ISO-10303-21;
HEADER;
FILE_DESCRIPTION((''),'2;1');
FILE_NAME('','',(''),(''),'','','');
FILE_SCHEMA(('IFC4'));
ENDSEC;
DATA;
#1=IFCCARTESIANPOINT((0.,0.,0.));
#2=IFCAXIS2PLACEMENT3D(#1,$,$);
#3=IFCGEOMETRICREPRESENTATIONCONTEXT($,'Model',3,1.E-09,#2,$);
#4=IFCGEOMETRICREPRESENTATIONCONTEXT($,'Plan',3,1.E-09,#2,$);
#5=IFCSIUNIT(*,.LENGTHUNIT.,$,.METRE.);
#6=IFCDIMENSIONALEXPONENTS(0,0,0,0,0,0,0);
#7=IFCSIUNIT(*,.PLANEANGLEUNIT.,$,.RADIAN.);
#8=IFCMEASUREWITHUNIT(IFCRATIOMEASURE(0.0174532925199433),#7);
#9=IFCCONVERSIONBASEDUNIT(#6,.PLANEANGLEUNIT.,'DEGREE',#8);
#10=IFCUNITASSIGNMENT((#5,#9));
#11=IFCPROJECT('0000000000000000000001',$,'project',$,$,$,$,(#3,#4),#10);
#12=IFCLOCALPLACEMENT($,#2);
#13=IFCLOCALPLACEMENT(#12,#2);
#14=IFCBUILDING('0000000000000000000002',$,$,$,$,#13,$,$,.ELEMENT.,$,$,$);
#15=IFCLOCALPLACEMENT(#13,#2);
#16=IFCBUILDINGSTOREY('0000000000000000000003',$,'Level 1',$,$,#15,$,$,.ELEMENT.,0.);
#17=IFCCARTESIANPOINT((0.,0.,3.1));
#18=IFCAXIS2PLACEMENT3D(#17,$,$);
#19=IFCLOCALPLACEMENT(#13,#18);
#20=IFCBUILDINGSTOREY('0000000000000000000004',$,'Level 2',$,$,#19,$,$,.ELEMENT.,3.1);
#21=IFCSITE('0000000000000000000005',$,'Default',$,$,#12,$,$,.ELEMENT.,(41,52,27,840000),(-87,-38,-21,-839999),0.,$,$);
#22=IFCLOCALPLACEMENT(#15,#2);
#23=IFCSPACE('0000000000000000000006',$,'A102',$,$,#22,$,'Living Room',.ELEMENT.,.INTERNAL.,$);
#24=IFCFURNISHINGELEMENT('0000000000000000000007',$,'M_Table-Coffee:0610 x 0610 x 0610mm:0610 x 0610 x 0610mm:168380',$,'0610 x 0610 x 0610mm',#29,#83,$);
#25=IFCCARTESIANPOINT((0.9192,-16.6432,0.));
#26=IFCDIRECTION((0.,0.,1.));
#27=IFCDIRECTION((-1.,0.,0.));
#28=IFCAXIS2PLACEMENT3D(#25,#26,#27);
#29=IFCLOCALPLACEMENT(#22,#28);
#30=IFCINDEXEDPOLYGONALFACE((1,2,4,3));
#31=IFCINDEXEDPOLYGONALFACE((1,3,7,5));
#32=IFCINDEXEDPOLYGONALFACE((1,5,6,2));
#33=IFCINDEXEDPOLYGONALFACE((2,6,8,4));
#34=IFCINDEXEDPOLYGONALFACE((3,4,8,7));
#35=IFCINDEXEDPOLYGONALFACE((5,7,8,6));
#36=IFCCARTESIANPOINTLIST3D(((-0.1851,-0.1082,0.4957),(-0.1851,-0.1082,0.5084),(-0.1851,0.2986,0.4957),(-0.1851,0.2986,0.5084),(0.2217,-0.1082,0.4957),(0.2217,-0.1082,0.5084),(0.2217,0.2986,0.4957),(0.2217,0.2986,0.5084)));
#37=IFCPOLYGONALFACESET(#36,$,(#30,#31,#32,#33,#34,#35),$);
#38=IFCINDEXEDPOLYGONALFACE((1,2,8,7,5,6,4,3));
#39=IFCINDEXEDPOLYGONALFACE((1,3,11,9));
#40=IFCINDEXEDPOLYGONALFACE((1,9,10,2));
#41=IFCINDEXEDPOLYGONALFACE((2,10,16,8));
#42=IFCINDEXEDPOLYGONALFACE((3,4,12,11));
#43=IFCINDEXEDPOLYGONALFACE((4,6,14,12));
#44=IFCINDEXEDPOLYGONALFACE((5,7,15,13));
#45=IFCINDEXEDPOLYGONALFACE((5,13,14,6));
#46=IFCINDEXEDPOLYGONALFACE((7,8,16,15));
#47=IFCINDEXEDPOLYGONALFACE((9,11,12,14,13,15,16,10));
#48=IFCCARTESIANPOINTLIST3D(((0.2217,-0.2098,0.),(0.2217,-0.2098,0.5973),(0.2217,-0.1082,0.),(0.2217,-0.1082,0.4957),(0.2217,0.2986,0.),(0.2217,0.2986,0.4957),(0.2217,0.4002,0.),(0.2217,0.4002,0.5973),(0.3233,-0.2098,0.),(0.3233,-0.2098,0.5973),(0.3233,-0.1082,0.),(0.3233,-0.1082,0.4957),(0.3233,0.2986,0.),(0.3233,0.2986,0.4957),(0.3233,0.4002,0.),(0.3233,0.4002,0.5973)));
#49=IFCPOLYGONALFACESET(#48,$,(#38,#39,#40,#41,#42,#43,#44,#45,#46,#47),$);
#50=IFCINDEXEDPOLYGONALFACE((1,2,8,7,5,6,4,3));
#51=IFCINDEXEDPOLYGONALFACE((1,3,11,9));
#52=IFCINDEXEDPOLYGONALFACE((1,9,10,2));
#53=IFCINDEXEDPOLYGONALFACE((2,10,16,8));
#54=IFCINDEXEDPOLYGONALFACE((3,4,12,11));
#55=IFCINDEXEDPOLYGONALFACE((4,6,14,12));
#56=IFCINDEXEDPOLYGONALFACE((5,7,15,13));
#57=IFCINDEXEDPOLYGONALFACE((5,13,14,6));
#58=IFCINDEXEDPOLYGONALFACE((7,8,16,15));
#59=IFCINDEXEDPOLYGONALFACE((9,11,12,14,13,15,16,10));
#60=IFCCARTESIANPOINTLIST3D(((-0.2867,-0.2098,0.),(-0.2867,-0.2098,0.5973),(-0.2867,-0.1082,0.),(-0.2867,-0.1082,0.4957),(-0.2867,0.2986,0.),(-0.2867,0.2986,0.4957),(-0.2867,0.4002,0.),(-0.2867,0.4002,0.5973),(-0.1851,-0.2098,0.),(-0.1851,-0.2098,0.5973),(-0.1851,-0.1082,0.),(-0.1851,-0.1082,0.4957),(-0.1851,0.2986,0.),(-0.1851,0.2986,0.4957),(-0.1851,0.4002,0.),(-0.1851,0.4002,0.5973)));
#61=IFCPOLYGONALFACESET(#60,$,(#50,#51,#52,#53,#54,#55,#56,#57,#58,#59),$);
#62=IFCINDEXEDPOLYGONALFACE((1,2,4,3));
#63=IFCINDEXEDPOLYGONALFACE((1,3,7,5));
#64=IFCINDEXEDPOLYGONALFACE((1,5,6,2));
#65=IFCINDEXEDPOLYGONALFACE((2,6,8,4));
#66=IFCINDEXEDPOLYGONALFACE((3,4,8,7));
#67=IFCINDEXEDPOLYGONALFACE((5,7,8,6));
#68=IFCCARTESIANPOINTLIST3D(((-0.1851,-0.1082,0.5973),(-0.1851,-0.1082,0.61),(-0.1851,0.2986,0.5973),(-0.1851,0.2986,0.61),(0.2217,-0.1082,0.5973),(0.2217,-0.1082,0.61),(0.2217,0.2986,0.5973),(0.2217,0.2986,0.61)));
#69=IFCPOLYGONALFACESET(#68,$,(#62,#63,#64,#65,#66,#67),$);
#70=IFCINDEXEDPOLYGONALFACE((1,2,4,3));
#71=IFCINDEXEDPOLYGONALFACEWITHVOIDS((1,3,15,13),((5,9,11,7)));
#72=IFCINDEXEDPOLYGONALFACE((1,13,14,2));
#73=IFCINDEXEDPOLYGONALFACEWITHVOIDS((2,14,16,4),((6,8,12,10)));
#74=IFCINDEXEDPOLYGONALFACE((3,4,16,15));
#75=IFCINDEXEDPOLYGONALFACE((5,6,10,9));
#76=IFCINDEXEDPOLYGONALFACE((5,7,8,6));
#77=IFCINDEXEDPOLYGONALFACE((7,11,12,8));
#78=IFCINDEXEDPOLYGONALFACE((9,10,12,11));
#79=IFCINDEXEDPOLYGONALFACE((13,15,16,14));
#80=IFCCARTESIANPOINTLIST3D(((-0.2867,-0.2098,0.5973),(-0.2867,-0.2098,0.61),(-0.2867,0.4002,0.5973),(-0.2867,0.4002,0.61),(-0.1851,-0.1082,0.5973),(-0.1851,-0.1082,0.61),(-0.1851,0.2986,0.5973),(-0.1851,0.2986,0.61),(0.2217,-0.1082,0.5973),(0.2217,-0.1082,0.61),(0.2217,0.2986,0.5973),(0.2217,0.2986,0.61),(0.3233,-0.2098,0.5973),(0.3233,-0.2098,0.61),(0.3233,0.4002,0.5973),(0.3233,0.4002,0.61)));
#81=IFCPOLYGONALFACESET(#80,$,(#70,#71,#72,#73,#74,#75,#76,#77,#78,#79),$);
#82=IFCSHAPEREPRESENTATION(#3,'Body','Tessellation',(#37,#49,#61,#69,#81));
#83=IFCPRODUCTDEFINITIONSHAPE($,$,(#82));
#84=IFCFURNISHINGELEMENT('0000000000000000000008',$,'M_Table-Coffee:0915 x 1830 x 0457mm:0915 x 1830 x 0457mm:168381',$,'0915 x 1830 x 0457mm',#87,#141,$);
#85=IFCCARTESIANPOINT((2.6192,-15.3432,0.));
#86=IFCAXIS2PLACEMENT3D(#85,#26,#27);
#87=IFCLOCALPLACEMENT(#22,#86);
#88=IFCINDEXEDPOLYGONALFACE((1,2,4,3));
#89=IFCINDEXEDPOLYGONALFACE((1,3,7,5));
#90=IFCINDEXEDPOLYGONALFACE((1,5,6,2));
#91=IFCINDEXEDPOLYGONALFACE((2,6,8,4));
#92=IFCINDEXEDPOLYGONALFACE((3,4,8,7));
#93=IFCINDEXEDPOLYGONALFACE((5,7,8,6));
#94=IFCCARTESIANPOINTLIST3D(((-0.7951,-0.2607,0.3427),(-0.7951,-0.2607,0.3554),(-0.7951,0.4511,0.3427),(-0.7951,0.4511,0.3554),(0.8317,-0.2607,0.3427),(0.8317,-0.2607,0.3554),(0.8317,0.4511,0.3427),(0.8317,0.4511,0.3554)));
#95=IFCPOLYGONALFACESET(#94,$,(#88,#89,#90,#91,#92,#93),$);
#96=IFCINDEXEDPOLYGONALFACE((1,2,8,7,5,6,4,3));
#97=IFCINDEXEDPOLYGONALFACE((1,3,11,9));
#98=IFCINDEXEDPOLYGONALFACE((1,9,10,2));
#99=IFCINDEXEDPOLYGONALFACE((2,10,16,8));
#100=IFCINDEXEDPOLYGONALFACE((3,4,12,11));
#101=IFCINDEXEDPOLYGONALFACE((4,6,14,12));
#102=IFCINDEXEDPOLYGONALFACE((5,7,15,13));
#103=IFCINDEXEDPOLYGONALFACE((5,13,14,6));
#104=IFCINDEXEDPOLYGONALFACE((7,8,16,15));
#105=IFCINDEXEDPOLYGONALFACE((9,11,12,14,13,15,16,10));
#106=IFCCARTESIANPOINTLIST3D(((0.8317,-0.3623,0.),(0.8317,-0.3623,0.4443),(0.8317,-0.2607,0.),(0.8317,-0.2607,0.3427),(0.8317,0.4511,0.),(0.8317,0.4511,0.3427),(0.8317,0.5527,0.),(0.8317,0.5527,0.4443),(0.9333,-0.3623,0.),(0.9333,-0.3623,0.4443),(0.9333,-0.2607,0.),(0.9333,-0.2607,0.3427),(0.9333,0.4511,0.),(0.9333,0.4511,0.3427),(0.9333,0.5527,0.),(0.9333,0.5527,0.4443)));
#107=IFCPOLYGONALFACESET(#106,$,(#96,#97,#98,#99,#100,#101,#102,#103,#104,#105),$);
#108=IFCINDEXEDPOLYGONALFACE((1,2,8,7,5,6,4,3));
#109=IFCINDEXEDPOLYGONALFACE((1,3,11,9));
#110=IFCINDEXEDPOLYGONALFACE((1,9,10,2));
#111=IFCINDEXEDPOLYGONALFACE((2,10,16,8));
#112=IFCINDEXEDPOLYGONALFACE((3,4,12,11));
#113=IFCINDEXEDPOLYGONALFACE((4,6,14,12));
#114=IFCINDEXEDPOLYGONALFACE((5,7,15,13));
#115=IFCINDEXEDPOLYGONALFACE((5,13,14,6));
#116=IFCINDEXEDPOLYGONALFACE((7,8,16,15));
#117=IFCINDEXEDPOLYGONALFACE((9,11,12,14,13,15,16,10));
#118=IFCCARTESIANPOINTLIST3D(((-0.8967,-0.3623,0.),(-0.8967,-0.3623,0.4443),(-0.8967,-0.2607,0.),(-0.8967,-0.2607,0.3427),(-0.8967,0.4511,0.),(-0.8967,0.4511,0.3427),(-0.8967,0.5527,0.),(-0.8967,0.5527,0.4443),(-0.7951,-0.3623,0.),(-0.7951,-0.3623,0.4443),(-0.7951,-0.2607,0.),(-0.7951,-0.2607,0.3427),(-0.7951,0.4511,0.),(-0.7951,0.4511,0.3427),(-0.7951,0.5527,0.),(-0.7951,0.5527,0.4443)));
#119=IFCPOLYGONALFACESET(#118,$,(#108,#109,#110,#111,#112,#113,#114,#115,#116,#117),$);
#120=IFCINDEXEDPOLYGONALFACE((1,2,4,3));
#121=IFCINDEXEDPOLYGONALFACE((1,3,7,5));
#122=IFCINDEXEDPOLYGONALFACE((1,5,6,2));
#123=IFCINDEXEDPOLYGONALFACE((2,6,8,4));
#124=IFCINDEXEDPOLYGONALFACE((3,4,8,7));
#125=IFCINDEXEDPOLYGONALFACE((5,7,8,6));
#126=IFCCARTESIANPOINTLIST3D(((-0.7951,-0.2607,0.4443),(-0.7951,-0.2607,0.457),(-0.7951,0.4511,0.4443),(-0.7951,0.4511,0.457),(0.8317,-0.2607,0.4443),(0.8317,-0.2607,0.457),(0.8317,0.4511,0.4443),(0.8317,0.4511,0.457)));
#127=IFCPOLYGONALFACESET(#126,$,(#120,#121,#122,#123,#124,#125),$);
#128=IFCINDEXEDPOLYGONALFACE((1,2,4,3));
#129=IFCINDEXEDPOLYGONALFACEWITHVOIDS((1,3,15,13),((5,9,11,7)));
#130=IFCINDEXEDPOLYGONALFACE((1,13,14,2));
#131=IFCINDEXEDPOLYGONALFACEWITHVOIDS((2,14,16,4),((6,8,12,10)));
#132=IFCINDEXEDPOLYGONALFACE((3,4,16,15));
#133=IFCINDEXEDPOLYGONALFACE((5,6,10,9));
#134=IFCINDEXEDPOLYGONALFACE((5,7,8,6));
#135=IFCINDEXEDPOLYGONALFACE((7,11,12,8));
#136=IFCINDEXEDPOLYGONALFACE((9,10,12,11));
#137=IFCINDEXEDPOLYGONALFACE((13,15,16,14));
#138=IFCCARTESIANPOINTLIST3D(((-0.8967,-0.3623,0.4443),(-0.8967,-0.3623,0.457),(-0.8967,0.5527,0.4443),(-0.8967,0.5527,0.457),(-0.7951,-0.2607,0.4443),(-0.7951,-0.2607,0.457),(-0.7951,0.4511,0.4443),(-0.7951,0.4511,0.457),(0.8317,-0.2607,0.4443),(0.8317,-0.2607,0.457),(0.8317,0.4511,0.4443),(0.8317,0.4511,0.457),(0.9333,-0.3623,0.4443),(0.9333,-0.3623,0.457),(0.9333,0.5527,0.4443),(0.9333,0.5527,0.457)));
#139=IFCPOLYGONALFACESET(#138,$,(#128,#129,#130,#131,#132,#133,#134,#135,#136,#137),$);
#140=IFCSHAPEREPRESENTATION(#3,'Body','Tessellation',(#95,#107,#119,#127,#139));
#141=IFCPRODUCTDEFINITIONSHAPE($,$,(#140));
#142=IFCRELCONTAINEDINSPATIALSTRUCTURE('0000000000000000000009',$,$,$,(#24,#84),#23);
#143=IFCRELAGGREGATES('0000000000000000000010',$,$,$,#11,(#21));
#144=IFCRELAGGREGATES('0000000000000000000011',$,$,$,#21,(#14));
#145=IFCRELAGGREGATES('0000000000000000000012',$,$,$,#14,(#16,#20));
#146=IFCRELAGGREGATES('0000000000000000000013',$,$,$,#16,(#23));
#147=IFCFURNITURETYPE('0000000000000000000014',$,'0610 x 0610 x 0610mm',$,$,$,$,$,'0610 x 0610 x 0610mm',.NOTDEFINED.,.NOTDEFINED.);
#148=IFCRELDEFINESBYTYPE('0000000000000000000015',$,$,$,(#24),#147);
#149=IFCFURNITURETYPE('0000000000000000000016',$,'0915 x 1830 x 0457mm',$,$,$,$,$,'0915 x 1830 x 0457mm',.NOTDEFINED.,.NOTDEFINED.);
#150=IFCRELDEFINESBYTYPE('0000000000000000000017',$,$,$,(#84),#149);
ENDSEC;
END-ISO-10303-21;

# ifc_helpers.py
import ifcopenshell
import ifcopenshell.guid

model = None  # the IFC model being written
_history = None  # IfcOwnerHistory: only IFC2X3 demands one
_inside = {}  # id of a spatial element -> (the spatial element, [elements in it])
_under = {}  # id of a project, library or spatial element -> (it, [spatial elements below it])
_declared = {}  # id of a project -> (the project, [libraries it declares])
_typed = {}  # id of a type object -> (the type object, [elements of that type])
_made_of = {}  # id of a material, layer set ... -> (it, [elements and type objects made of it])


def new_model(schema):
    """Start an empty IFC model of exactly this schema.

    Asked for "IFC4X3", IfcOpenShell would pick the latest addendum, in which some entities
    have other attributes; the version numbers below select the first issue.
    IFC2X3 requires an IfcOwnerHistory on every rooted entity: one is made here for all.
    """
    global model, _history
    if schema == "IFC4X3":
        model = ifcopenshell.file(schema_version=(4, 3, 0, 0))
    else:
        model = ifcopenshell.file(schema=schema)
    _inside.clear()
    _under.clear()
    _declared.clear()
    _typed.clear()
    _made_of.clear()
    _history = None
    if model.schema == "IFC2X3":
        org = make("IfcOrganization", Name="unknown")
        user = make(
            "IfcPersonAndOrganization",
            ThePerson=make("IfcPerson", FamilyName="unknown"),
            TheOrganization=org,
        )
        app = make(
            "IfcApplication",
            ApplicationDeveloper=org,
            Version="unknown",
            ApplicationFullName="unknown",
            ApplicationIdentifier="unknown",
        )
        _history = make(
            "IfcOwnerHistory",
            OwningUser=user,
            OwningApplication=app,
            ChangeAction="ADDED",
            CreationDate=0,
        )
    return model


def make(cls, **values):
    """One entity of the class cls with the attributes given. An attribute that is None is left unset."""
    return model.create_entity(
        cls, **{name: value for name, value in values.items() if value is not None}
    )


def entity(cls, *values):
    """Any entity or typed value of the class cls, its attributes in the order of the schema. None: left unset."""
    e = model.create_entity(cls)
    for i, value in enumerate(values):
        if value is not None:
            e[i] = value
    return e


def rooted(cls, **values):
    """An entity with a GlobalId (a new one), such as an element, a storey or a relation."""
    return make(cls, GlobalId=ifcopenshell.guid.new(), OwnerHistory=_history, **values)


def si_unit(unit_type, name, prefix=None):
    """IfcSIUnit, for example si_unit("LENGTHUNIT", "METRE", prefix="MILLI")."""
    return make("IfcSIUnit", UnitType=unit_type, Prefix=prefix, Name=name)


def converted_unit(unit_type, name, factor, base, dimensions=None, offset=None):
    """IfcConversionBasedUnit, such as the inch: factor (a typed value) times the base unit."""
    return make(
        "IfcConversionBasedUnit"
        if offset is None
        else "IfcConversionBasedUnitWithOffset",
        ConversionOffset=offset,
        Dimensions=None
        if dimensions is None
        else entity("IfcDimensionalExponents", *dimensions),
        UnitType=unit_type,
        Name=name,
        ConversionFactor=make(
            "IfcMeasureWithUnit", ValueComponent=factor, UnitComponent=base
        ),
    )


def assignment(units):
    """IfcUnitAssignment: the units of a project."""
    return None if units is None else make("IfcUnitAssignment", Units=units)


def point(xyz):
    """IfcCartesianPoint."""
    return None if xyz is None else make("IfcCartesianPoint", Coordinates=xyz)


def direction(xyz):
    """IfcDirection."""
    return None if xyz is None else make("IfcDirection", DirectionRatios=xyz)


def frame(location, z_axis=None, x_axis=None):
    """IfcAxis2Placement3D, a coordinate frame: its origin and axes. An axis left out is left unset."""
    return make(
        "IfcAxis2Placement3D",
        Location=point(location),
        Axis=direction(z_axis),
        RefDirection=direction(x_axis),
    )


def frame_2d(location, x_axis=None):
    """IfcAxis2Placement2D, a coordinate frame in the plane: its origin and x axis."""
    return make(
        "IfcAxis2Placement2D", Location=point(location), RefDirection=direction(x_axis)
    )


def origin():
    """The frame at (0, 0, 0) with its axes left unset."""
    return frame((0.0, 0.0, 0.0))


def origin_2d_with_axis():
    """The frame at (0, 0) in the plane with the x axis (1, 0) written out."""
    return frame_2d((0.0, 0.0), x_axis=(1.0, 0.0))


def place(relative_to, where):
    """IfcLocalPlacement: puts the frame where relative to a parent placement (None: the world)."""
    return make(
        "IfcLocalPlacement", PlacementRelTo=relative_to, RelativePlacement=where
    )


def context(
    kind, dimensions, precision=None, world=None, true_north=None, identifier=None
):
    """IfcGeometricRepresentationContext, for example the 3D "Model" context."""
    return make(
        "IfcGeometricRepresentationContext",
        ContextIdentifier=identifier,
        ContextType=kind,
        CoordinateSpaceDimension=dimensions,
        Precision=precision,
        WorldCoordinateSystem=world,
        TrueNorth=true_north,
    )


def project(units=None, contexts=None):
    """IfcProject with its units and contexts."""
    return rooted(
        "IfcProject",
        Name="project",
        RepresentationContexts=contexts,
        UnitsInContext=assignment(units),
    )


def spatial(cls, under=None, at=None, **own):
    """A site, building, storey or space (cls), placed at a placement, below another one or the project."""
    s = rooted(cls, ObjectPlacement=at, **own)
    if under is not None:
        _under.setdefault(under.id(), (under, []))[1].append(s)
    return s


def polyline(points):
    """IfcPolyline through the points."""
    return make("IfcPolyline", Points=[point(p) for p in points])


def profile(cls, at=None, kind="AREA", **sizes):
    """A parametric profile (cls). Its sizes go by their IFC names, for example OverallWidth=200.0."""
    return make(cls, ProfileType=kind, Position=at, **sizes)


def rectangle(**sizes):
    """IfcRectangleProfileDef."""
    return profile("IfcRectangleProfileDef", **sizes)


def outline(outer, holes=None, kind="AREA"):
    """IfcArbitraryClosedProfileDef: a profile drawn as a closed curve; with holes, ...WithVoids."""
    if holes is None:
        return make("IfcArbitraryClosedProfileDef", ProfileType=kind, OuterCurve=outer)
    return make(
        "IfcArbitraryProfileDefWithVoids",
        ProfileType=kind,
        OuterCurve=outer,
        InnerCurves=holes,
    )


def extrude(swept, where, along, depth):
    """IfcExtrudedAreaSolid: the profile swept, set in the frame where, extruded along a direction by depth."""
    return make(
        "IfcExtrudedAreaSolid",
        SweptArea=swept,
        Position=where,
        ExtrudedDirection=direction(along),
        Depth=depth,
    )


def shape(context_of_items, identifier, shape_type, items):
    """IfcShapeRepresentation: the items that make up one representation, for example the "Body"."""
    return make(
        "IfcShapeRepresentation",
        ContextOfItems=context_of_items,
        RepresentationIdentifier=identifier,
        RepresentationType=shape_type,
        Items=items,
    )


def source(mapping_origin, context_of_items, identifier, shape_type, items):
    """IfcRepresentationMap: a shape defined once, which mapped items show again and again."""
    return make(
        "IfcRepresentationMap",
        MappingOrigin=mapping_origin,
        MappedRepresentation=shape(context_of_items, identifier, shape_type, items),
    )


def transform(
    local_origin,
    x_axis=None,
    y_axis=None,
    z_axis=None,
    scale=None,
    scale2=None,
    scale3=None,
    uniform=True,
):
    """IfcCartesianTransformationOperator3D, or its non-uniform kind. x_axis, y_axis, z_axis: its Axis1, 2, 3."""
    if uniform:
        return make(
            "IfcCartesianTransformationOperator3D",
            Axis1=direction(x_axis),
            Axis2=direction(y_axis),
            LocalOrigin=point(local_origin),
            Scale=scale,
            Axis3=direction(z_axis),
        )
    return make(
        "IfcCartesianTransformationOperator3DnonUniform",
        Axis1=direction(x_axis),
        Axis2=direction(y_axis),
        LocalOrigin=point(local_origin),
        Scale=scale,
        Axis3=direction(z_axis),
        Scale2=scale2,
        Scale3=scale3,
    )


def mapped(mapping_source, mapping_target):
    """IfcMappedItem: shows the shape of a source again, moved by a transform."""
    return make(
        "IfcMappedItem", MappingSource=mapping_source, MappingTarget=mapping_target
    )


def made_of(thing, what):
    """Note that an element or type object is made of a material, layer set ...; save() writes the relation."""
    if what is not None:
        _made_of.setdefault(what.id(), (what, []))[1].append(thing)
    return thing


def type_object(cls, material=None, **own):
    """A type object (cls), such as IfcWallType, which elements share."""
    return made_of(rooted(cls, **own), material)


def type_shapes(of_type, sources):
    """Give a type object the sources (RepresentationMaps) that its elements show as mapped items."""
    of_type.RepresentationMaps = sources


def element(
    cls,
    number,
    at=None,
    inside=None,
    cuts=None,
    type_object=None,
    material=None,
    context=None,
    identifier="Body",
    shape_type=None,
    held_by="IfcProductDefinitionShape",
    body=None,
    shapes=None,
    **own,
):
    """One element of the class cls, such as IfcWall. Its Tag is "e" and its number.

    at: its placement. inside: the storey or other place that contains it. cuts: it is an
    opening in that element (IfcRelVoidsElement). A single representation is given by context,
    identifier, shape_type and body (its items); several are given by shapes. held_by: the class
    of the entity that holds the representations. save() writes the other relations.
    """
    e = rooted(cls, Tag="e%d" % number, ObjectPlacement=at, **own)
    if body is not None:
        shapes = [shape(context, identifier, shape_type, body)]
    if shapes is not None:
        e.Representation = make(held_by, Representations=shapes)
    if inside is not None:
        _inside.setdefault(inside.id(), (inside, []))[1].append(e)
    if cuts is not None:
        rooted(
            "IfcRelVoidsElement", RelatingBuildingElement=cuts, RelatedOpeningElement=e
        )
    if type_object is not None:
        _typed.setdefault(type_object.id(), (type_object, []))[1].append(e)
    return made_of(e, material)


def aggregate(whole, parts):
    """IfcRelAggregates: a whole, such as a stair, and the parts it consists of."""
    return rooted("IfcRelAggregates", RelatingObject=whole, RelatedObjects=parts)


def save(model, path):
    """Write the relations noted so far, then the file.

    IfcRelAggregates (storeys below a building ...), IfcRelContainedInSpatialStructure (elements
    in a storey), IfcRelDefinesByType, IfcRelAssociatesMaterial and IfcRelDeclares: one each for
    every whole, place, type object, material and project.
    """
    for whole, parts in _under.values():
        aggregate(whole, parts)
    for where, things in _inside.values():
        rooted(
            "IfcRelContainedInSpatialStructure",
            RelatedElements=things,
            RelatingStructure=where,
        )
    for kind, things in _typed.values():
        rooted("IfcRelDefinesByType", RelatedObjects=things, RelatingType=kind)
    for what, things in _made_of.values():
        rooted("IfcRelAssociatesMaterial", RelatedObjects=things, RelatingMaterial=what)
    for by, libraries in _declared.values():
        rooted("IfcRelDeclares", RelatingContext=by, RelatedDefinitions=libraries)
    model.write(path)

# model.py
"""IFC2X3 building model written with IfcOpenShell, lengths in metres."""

from ifc_helpers import new_model, entity, si_unit, converted_unit, frame, origin, origin_2d_with_axis, place, context, project, spatial, polyline, rectangle, outline, extrude, source, transform, mapped, type_object, type_shapes, element, save


model = new_model("IFC2X3")

# Units and contexts
model_context = context("Model", 3, precision=1e-09, world=origin())
plan_context = context("Plan", 3, precision=1e-09, world=origin())
ifc_project = project(units=[si_unit("LENGTHUNIT", "METRE"), converted_unit("PLANEANGLEUNIT", "DEGREE", entity("IfcRatioMeasure", 0.0174532925199433), si_unit("PLANEANGLEUNIT", "RADIAN"), dimensions=[0, 0, 0, 0, 0, 0, 0])], contexts=[model_context, plan_context])

# Site, building, storey
site_placement = place(None, origin())
site = spatial("IfcSite", under=ifc_project, at=site_placement, Name="Default", CompositionType="ELEMENT", RefLatitude=(41, 52, 27, 840000), RefLongitude=(-87, -38, -21, -839999), RefElevation=0.0)
building_placement = place(site_placement, origin())
building = spatial("IfcBuilding", under=site, at=building_placement, CompositionType="ELEMENT")
storey_1_placement = place(building_placement, origin())
storey_1 = spatial("IfcBuildingStorey", under=building, at=storey_1_placement, Name="Level 1", CompositionType="ELEMENT", Elevation=0.0)

# Shared definitions
storey_2_placement = place(building_placement, frame((0.0, 0.0, 3.1)))
storey_2 = spatial("IfcBuildingStorey", under=building, at=storey_2_placement, Name="Level 2", CompositionType="ELEMENT", Elevation=3.1)

# Shared definitions
space_1_placement = place(storey_1_placement, origin())
space_1 = spatial("IfcSpace", under=storey_1, at=space_1_placement, Name="A102", LongName="Living Room", CompositionType="ELEMENT", InteriorOrExteriorSpace="INTERNAL")

# Furnishing elements
furniture_type_1 = type_object("IfcFurnitureType", Name="0610 x 0610 x 0610mm", ElementType="0610 x 0610 x 0610mm", AssemblyPlace="NOTDEFINED")
shared_shape_1 = source(origin(), model_context, "Body", "SweptSolid", [
    extrude(rectangle(XDim=0.4068, YDim=0.4068, at=origin_2d_with_axis()), frame((0.0183, 0.0952, 0.4957), z_axis=(0.0, 0.0, 1.0), x_axis=(-1.0, 0.0, 0.0)), (0.0, 0.0, 1.0), 0.0127),
    extrude(outline(polyline([(-0.2732, -0.305), (0.324, -0.305), (0.324, 0.305), (-0.2732, 0.305), (-0.2732, 0.2034), (0.2225, 0.2034), (0.2225, -0.2034), (-0.2732, -0.2034), (-0.2732, -0.305)])), frame((0.2217, 0.0952, 0.2732), z_axis=(1.0, 0.0, 0.0), x_axis=(0.0, 0.0, 1.0)), (0.0, 0.0, 1.0), 0.1016),
    extrude(outline(polyline([(-0.305, -0.3241), (0.305, -0.3241), (0.305, 0.2733), (0.2034, 0.2733), (0.2034, -0.2224), (-0.2034, -0.2224), (-0.2034, 0.2733), (-0.305, 0.2733), (-0.305, -0.3241)])), frame((-0.2867, 0.0952, 0.2733), z_axis=(1.0, 0.0, 0.0), x_axis=(0.0, -1.0, 0.0)), (0.0, 0.0, 1.0), 0.1016),
    extrude(rectangle(XDim=0.4068, YDim=0.4068, at=origin_2d_with_axis()), frame((0.0183, 0.0952, 0.5973), z_axis=(0.0, 0.0, 1.0), x_axis=(-1.0, 0.0, 0.0)), (0.0, 0.0, 1.0), 0.0127),
    extrude(outline(polyline([(-0.305, -0.305), (0.305, -0.305), (0.305, 0.305), (-0.305, 0.305), (-0.305, -0.305)]), holes=[polyline([(-0.2034, -0.2034), (-0.2034, 0.2034), (0.2034, 0.2034), (0.2034, -0.2034), (-0.2034, -0.2034)])]), frame((0.0183, 0.0952, 0.5973), z_axis=(0.0, 0.0, 1.0), x_axis=(-1.0, 0.0, 0.0)), (0.0, 0.0, 1.0), 0.0127),
])
type_shapes(furniture_type_1, [shared_shape_1])
for number, where, z_axis, x_axis, name in (
    (1, (0.9192, -16.6432, 0.0), (0.0, 0.0, 1.0), (-1.0, 0.0, 0.0), "M_Table-Coffee:0610 x 0610 x 0610mm:0610 x 0610 x 0610mm:168380"),
):
    element("IfcFurnishingElement", number, at=place(space_1_placement, frame(where, z_axis=z_axis, x_axis=x_axis)), inside=space_1, type_object=furniture_type_1, Name=name, ObjectType="0610 x 0610 x 0610mm", context=model_context, shape_type="MappedRepresentation", body=[
        mapped(shared_shape_1, transform((0.0, 0.0, 0.0), scale=1.0)),
    ])
furniture_type_2 = type_object("IfcFurnitureType", Name="0915 x 1830 x 0457mm", ElementType="0915 x 1830 x 0457mm", AssemblyPlace="NOTDEFINED")
shared_shape_2 = source(origin(), model_context, "Body", "SweptSolid", [
    extrude(rectangle(XDim=1.6268, YDim=0.7118, at=origin_2d_with_axis()), frame((0.0183, 0.0952, 0.3427), z_axis=(0.0, 0.0, 1.0), x_axis=(-1.0, 0.0, 0.0)), (0.0, 0.0, 1.0), 0.0127),
    extrude(outline(polyline([(-0.1967, -0.4575), (0.2475, -0.4575), (0.2475, 0.4575), (-0.1967, 0.4575), (-0.1967, 0.3559), (0.146, 0.3559), (0.146, -0.3559), (-0.1967, -0.3559), (-0.1967, -0.4575)])), frame((0.8317, 0.0952, 0.1967), z_axis=(1.0, 0.0, 0.0), x_axis=(0.0, 0.0, 1.0)), (0.0, 0.0, 1.0), 0.1016),
    extrude(outline(polyline([(-0.4575, -0.2476), (0.4575, -0.2476), (0.4575, 0.1968), (0.3559, 0.1968), (0.3559, -0.1459), (-0.3559, -0.1459), (-0.3559, 0.1968), (-0.4575, 0.1968), (-0.4575, -0.2476)])), frame((-0.8967, 0.0952, 0.1968), z_axis=(1.0, 0.0, 0.0), x_axis=(0.0, -1.0, 0.0)), (0.0, 0.0, 1.0), 0.1016),
    extrude(rectangle(XDim=1.6268, YDim=0.7118, at=origin_2d_with_axis()), frame((0.0183, 0.0952, 0.4443), z_axis=(0.0, 0.0, 1.0), x_axis=(-1.0, 0.0, 0.0)), (0.0, 0.0, 1.0), 0.0127),
    extrude(outline(polyline([(-0.915, -0.4575), (0.915, -0.4575), (0.915, 0.4575), (-0.915, 0.4575), (-0.915, -0.4575)]), holes=[polyline([(-0.8134, -0.3559), (-0.8134, 0.3559), (0.8134, 0.3559), (0.8134, -0.3559), (-0.8134, -0.3559)])]), frame((0.0183, 0.0952, 0.4443), z_axis=(0.0, 0.0, 1.0), x_axis=(-1.0, 0.0, 0.0)), (0.0, 0.0, 1.0), 0.0127),
])
type_shapes(furniture_type_2, [shared_shape_2])
furnishing_1_placement = place(space_1_placement, frame((2.6192, -15.3432, 0.0), z_axis=(0.0, 0.0, 1.0), x_axis=(-1.0, 0.0, 0.0)))
element("IfcFurnishingElement", 2, at=furnishing_1_placement, inside=space_1, type_object=furniture_type_2, Name="M_Table-Coffee:0915 x 1830 x 0457mm:0915 x 1830 x 0457mm:168381", ObjectType="0915 x 1830 x 0457mm", context=model_context, shape_type="MappedRepresentation", body=[
    mapped(shared_shape_2, transform((0.0, 0.0, 0.0), scale=1.0)),
])

save(model, "model.ifc")
